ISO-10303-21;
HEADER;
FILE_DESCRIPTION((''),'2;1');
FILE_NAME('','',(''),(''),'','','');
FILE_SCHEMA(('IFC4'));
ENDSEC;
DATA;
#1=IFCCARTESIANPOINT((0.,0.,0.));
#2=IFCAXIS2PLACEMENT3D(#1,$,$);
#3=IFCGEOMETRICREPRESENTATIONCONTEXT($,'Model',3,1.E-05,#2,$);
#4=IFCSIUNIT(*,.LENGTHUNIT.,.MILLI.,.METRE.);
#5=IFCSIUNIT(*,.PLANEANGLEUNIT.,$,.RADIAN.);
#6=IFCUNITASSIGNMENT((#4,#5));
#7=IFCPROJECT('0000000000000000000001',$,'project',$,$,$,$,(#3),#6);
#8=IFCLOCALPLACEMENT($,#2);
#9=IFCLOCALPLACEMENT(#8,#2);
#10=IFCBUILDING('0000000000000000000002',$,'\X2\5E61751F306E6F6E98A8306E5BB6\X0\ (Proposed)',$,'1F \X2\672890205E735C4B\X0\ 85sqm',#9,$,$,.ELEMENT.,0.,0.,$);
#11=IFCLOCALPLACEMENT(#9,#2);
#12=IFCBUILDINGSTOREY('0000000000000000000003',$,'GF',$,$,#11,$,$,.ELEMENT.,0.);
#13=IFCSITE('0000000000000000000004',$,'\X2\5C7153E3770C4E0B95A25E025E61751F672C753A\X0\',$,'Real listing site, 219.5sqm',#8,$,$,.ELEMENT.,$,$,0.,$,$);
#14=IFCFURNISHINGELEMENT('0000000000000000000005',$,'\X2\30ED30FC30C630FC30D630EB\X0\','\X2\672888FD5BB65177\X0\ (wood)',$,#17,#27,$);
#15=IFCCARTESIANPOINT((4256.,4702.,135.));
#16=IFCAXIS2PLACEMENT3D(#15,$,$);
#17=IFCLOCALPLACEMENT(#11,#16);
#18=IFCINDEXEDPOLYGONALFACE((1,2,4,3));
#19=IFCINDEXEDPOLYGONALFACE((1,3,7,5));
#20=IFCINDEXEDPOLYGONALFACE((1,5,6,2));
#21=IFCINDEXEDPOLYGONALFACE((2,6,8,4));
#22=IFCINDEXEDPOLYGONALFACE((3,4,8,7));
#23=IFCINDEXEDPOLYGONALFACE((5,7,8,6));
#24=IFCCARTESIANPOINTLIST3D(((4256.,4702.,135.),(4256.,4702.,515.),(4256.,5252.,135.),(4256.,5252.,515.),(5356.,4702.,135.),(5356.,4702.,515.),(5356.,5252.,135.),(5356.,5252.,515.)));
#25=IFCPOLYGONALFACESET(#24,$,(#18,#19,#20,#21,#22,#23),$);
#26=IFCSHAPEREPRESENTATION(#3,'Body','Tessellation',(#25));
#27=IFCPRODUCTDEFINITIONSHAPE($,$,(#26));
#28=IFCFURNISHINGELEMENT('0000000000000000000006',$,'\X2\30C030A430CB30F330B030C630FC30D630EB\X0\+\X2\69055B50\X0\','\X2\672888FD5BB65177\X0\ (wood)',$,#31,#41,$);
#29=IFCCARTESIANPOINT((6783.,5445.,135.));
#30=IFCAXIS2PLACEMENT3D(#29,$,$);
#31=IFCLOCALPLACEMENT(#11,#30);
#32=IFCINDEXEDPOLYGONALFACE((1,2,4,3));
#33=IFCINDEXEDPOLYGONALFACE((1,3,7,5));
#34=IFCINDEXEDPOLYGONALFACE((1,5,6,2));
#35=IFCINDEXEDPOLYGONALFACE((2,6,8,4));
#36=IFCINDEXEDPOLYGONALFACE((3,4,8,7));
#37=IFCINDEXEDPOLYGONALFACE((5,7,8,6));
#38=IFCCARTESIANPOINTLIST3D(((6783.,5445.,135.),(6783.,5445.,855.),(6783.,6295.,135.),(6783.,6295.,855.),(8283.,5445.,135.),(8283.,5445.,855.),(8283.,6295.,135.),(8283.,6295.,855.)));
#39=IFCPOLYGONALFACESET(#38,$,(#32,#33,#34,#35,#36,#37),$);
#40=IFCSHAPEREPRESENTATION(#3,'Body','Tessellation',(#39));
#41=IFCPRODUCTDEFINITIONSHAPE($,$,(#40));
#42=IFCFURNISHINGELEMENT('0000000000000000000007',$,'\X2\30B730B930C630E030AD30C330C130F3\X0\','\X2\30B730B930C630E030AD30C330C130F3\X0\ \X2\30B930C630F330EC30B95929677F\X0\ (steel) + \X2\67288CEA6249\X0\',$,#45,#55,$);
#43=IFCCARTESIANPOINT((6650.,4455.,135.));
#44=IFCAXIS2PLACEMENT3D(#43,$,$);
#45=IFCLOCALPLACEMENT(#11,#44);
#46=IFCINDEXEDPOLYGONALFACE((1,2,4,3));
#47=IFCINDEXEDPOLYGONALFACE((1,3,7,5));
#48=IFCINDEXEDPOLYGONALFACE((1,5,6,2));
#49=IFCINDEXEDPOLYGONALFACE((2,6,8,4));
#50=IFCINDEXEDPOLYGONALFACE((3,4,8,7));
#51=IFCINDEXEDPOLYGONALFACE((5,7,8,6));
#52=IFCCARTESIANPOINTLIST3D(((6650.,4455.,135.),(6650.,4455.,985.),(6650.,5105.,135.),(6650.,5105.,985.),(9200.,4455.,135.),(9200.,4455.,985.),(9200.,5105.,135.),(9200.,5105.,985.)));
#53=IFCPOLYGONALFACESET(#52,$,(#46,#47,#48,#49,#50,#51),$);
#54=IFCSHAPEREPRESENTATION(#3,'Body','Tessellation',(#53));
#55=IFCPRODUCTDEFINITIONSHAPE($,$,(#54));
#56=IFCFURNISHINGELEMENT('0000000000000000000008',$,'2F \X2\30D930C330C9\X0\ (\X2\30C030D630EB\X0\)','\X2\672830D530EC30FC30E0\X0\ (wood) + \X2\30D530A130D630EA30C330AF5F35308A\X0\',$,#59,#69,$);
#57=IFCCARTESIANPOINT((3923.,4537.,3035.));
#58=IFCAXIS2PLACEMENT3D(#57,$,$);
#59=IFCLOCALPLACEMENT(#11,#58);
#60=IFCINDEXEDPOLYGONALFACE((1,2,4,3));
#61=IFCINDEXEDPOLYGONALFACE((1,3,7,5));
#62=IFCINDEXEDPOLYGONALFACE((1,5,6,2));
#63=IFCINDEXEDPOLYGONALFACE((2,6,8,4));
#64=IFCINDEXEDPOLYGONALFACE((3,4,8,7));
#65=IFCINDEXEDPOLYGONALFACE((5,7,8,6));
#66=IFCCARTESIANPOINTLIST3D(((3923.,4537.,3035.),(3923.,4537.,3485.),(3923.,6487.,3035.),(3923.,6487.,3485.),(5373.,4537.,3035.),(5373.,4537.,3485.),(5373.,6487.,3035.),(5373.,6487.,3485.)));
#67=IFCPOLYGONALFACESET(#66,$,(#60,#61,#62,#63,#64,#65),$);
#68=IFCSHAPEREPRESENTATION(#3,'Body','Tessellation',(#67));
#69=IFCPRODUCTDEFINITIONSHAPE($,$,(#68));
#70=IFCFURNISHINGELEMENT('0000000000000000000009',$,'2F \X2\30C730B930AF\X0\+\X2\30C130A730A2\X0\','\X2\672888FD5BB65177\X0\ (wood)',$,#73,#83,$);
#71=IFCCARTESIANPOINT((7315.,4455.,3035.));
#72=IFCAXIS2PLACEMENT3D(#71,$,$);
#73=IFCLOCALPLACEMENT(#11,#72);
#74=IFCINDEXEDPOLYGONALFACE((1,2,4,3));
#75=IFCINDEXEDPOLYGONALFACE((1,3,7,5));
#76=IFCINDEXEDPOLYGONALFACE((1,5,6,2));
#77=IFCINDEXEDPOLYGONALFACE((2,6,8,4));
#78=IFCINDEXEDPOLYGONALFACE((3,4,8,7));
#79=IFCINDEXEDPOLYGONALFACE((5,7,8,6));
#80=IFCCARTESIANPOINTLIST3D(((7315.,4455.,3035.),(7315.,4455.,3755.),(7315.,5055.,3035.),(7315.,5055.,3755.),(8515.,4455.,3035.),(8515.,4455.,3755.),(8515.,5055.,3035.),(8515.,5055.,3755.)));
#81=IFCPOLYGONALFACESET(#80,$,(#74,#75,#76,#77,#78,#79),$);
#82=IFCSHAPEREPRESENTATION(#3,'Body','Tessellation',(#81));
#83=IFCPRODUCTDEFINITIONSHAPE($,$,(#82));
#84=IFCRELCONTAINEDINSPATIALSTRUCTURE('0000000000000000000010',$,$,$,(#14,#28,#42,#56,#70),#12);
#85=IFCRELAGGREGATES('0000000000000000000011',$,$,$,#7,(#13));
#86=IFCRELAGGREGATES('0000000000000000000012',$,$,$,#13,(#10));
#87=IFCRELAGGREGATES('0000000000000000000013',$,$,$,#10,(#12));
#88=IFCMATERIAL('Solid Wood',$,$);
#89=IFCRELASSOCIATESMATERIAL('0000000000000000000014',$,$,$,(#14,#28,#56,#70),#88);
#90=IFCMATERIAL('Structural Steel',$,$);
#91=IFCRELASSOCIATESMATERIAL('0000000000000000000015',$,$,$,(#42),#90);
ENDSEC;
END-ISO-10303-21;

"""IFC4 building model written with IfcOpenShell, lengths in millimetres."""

from ifc_helpers import new_model, si_unit, frame, frame_2d, origin, place, context, project, spatial, rectangle, extrude, material, element, save


model = new_model("IFC4")

# Units and contexts
model_context = context("Model", 3, precision=1e-05, world=origin())
ifc_project = project(units=[si_unit("LENGTHUNIT", "METRE", prefix="MILLI"), si_unit("PLANEANGLEUNIT", "RADIAN")], contexts=[model_context])

# Site, building, storey
site_placement = place(None, origin())
site = spatial("IfcSite", under=ifc_project, at=site_placement, Name="山口県下関市幡生本町", ObjectType="Real listing site, 219.5sqm", CompositionType="ELEMENT", RefElevation=0.0)
building_placement = place(site_placement, origin())
building = spatial("IfcBuilding", under=site, at=building_placement, Name="幡生の潮風の家 (Proposed)", ObjectType="1F 木造平屋 85sqm", CompositionType="ELEMENT", ElevationOfRefHeight=0.0, ElevationOfTerrain=0.0)
storey_placement = place(building_placement, origin())
storey = spatial("IfcBuildingStorey", under=building, at=storey_placement, Name="GF", CompositionType="ELEMENT", Elevation=0.0)

# Shared definitions
ifc_material_1 = material(Name="Solid Wood")

# Shared definitions
ifc_material_2 = material(Name="Structural Steel")

# Furnishing elements
furnishing_1_placement = place(storey_placement, frame((4256.0, 4702.0, 135.0)))
element("IfcFurnishingElement", 1, at=furnishing_1_placement, inside=storey, material=ifc_material_1, Name="ローテーブル", Description="木製家具 (wood)", context=model_context, shape_type="SweptSolid", body=[
    extrude(rectangle(XDim=1100.0, YDim=550.0, at=frame_2d((550.0, 275.0))), frame((4256.0, 4702.0, 135.0)), (0.0, 0.0, 1.0), 380.0),
])
furnishing_2_placement = place(storey_placement, frame((6783.0, 5445.0, 135.0)))
element("IfcFurnishingElement", 2, at=furnishing_2_placement, inside=storey, material=ifc_material_1, Name="ダイニングテーブル+椅子", Description="木製家具 (wood)", context=model_context, shape_type="SweptSolid", body=[
    extrude(rectangle(XDim=1500.0, YDim=850.0, at=frame_2d((750.0, 425.0))), frame((6783.0, 5445.0, 135.0)), (0.0, 0.0, 1.0), 720.0),
])
furnishing_3_placement = place(storey_placement, frame((6650.0, 4455.0, 135.0)))
element("IfcFurnishingElement", 3, at=furnishing_3_placement, inside=storey, material=ifc_material_2, Name="システムキッチン", Description="システムキッチン ステンレス天板 (steel) + 木質扉", context=model_context, shape_type="SweptSolid", body=[
    extrude(rectangle(XDim=2550.0, YDim=650.0, at=frame_2d((1275.0, 325.0))), frame((6650.0, 4455.0, 135.0)), (0.0, 0.0, 1.0), 850.0),
])
furnishing_4_placement = place(storey_placement, frame((3923.0, 4537.0, 3035.0)))
element("IfcFurnishingElement", 4, at=furnishing_4_placement, inside=storey, material=ifc_material_1, Name="2F ベッド (ダブル)", Description="木フレーム (wood) + ファブリック張り", context=model_context, shape_type="SweptSolid", body=[
    extrude(rectangle(XDim=1450.0, YDim=1950.0, at=frame_2d((725.0, 975.0))), frame((3923.0, 4537.0, 3035.0)), (0.0, 0.0, 1.0), 450.0),
])
furnishing_5_placement = place(storey_placement, frame((7315.0, 4455.0, 3035.0)))
element("IfcFurnishingElement", 5, at=furnishing_5_placement, inside=storey, material=ifc_material_1, Name="2F デスク+チェア", Description="木製家具 (wood)", context=model_context, shape_type="SweptSolid", body=[
    extrude(rectangle(XDim=1200.0, YDim=600.0, at=frame_2d((600.0, 300.0))), frame((7315.0, 4455.0, 3035.0)), (0.0, 0.0, 1.0), 720.0),
])

save(model, "model.ifc")
